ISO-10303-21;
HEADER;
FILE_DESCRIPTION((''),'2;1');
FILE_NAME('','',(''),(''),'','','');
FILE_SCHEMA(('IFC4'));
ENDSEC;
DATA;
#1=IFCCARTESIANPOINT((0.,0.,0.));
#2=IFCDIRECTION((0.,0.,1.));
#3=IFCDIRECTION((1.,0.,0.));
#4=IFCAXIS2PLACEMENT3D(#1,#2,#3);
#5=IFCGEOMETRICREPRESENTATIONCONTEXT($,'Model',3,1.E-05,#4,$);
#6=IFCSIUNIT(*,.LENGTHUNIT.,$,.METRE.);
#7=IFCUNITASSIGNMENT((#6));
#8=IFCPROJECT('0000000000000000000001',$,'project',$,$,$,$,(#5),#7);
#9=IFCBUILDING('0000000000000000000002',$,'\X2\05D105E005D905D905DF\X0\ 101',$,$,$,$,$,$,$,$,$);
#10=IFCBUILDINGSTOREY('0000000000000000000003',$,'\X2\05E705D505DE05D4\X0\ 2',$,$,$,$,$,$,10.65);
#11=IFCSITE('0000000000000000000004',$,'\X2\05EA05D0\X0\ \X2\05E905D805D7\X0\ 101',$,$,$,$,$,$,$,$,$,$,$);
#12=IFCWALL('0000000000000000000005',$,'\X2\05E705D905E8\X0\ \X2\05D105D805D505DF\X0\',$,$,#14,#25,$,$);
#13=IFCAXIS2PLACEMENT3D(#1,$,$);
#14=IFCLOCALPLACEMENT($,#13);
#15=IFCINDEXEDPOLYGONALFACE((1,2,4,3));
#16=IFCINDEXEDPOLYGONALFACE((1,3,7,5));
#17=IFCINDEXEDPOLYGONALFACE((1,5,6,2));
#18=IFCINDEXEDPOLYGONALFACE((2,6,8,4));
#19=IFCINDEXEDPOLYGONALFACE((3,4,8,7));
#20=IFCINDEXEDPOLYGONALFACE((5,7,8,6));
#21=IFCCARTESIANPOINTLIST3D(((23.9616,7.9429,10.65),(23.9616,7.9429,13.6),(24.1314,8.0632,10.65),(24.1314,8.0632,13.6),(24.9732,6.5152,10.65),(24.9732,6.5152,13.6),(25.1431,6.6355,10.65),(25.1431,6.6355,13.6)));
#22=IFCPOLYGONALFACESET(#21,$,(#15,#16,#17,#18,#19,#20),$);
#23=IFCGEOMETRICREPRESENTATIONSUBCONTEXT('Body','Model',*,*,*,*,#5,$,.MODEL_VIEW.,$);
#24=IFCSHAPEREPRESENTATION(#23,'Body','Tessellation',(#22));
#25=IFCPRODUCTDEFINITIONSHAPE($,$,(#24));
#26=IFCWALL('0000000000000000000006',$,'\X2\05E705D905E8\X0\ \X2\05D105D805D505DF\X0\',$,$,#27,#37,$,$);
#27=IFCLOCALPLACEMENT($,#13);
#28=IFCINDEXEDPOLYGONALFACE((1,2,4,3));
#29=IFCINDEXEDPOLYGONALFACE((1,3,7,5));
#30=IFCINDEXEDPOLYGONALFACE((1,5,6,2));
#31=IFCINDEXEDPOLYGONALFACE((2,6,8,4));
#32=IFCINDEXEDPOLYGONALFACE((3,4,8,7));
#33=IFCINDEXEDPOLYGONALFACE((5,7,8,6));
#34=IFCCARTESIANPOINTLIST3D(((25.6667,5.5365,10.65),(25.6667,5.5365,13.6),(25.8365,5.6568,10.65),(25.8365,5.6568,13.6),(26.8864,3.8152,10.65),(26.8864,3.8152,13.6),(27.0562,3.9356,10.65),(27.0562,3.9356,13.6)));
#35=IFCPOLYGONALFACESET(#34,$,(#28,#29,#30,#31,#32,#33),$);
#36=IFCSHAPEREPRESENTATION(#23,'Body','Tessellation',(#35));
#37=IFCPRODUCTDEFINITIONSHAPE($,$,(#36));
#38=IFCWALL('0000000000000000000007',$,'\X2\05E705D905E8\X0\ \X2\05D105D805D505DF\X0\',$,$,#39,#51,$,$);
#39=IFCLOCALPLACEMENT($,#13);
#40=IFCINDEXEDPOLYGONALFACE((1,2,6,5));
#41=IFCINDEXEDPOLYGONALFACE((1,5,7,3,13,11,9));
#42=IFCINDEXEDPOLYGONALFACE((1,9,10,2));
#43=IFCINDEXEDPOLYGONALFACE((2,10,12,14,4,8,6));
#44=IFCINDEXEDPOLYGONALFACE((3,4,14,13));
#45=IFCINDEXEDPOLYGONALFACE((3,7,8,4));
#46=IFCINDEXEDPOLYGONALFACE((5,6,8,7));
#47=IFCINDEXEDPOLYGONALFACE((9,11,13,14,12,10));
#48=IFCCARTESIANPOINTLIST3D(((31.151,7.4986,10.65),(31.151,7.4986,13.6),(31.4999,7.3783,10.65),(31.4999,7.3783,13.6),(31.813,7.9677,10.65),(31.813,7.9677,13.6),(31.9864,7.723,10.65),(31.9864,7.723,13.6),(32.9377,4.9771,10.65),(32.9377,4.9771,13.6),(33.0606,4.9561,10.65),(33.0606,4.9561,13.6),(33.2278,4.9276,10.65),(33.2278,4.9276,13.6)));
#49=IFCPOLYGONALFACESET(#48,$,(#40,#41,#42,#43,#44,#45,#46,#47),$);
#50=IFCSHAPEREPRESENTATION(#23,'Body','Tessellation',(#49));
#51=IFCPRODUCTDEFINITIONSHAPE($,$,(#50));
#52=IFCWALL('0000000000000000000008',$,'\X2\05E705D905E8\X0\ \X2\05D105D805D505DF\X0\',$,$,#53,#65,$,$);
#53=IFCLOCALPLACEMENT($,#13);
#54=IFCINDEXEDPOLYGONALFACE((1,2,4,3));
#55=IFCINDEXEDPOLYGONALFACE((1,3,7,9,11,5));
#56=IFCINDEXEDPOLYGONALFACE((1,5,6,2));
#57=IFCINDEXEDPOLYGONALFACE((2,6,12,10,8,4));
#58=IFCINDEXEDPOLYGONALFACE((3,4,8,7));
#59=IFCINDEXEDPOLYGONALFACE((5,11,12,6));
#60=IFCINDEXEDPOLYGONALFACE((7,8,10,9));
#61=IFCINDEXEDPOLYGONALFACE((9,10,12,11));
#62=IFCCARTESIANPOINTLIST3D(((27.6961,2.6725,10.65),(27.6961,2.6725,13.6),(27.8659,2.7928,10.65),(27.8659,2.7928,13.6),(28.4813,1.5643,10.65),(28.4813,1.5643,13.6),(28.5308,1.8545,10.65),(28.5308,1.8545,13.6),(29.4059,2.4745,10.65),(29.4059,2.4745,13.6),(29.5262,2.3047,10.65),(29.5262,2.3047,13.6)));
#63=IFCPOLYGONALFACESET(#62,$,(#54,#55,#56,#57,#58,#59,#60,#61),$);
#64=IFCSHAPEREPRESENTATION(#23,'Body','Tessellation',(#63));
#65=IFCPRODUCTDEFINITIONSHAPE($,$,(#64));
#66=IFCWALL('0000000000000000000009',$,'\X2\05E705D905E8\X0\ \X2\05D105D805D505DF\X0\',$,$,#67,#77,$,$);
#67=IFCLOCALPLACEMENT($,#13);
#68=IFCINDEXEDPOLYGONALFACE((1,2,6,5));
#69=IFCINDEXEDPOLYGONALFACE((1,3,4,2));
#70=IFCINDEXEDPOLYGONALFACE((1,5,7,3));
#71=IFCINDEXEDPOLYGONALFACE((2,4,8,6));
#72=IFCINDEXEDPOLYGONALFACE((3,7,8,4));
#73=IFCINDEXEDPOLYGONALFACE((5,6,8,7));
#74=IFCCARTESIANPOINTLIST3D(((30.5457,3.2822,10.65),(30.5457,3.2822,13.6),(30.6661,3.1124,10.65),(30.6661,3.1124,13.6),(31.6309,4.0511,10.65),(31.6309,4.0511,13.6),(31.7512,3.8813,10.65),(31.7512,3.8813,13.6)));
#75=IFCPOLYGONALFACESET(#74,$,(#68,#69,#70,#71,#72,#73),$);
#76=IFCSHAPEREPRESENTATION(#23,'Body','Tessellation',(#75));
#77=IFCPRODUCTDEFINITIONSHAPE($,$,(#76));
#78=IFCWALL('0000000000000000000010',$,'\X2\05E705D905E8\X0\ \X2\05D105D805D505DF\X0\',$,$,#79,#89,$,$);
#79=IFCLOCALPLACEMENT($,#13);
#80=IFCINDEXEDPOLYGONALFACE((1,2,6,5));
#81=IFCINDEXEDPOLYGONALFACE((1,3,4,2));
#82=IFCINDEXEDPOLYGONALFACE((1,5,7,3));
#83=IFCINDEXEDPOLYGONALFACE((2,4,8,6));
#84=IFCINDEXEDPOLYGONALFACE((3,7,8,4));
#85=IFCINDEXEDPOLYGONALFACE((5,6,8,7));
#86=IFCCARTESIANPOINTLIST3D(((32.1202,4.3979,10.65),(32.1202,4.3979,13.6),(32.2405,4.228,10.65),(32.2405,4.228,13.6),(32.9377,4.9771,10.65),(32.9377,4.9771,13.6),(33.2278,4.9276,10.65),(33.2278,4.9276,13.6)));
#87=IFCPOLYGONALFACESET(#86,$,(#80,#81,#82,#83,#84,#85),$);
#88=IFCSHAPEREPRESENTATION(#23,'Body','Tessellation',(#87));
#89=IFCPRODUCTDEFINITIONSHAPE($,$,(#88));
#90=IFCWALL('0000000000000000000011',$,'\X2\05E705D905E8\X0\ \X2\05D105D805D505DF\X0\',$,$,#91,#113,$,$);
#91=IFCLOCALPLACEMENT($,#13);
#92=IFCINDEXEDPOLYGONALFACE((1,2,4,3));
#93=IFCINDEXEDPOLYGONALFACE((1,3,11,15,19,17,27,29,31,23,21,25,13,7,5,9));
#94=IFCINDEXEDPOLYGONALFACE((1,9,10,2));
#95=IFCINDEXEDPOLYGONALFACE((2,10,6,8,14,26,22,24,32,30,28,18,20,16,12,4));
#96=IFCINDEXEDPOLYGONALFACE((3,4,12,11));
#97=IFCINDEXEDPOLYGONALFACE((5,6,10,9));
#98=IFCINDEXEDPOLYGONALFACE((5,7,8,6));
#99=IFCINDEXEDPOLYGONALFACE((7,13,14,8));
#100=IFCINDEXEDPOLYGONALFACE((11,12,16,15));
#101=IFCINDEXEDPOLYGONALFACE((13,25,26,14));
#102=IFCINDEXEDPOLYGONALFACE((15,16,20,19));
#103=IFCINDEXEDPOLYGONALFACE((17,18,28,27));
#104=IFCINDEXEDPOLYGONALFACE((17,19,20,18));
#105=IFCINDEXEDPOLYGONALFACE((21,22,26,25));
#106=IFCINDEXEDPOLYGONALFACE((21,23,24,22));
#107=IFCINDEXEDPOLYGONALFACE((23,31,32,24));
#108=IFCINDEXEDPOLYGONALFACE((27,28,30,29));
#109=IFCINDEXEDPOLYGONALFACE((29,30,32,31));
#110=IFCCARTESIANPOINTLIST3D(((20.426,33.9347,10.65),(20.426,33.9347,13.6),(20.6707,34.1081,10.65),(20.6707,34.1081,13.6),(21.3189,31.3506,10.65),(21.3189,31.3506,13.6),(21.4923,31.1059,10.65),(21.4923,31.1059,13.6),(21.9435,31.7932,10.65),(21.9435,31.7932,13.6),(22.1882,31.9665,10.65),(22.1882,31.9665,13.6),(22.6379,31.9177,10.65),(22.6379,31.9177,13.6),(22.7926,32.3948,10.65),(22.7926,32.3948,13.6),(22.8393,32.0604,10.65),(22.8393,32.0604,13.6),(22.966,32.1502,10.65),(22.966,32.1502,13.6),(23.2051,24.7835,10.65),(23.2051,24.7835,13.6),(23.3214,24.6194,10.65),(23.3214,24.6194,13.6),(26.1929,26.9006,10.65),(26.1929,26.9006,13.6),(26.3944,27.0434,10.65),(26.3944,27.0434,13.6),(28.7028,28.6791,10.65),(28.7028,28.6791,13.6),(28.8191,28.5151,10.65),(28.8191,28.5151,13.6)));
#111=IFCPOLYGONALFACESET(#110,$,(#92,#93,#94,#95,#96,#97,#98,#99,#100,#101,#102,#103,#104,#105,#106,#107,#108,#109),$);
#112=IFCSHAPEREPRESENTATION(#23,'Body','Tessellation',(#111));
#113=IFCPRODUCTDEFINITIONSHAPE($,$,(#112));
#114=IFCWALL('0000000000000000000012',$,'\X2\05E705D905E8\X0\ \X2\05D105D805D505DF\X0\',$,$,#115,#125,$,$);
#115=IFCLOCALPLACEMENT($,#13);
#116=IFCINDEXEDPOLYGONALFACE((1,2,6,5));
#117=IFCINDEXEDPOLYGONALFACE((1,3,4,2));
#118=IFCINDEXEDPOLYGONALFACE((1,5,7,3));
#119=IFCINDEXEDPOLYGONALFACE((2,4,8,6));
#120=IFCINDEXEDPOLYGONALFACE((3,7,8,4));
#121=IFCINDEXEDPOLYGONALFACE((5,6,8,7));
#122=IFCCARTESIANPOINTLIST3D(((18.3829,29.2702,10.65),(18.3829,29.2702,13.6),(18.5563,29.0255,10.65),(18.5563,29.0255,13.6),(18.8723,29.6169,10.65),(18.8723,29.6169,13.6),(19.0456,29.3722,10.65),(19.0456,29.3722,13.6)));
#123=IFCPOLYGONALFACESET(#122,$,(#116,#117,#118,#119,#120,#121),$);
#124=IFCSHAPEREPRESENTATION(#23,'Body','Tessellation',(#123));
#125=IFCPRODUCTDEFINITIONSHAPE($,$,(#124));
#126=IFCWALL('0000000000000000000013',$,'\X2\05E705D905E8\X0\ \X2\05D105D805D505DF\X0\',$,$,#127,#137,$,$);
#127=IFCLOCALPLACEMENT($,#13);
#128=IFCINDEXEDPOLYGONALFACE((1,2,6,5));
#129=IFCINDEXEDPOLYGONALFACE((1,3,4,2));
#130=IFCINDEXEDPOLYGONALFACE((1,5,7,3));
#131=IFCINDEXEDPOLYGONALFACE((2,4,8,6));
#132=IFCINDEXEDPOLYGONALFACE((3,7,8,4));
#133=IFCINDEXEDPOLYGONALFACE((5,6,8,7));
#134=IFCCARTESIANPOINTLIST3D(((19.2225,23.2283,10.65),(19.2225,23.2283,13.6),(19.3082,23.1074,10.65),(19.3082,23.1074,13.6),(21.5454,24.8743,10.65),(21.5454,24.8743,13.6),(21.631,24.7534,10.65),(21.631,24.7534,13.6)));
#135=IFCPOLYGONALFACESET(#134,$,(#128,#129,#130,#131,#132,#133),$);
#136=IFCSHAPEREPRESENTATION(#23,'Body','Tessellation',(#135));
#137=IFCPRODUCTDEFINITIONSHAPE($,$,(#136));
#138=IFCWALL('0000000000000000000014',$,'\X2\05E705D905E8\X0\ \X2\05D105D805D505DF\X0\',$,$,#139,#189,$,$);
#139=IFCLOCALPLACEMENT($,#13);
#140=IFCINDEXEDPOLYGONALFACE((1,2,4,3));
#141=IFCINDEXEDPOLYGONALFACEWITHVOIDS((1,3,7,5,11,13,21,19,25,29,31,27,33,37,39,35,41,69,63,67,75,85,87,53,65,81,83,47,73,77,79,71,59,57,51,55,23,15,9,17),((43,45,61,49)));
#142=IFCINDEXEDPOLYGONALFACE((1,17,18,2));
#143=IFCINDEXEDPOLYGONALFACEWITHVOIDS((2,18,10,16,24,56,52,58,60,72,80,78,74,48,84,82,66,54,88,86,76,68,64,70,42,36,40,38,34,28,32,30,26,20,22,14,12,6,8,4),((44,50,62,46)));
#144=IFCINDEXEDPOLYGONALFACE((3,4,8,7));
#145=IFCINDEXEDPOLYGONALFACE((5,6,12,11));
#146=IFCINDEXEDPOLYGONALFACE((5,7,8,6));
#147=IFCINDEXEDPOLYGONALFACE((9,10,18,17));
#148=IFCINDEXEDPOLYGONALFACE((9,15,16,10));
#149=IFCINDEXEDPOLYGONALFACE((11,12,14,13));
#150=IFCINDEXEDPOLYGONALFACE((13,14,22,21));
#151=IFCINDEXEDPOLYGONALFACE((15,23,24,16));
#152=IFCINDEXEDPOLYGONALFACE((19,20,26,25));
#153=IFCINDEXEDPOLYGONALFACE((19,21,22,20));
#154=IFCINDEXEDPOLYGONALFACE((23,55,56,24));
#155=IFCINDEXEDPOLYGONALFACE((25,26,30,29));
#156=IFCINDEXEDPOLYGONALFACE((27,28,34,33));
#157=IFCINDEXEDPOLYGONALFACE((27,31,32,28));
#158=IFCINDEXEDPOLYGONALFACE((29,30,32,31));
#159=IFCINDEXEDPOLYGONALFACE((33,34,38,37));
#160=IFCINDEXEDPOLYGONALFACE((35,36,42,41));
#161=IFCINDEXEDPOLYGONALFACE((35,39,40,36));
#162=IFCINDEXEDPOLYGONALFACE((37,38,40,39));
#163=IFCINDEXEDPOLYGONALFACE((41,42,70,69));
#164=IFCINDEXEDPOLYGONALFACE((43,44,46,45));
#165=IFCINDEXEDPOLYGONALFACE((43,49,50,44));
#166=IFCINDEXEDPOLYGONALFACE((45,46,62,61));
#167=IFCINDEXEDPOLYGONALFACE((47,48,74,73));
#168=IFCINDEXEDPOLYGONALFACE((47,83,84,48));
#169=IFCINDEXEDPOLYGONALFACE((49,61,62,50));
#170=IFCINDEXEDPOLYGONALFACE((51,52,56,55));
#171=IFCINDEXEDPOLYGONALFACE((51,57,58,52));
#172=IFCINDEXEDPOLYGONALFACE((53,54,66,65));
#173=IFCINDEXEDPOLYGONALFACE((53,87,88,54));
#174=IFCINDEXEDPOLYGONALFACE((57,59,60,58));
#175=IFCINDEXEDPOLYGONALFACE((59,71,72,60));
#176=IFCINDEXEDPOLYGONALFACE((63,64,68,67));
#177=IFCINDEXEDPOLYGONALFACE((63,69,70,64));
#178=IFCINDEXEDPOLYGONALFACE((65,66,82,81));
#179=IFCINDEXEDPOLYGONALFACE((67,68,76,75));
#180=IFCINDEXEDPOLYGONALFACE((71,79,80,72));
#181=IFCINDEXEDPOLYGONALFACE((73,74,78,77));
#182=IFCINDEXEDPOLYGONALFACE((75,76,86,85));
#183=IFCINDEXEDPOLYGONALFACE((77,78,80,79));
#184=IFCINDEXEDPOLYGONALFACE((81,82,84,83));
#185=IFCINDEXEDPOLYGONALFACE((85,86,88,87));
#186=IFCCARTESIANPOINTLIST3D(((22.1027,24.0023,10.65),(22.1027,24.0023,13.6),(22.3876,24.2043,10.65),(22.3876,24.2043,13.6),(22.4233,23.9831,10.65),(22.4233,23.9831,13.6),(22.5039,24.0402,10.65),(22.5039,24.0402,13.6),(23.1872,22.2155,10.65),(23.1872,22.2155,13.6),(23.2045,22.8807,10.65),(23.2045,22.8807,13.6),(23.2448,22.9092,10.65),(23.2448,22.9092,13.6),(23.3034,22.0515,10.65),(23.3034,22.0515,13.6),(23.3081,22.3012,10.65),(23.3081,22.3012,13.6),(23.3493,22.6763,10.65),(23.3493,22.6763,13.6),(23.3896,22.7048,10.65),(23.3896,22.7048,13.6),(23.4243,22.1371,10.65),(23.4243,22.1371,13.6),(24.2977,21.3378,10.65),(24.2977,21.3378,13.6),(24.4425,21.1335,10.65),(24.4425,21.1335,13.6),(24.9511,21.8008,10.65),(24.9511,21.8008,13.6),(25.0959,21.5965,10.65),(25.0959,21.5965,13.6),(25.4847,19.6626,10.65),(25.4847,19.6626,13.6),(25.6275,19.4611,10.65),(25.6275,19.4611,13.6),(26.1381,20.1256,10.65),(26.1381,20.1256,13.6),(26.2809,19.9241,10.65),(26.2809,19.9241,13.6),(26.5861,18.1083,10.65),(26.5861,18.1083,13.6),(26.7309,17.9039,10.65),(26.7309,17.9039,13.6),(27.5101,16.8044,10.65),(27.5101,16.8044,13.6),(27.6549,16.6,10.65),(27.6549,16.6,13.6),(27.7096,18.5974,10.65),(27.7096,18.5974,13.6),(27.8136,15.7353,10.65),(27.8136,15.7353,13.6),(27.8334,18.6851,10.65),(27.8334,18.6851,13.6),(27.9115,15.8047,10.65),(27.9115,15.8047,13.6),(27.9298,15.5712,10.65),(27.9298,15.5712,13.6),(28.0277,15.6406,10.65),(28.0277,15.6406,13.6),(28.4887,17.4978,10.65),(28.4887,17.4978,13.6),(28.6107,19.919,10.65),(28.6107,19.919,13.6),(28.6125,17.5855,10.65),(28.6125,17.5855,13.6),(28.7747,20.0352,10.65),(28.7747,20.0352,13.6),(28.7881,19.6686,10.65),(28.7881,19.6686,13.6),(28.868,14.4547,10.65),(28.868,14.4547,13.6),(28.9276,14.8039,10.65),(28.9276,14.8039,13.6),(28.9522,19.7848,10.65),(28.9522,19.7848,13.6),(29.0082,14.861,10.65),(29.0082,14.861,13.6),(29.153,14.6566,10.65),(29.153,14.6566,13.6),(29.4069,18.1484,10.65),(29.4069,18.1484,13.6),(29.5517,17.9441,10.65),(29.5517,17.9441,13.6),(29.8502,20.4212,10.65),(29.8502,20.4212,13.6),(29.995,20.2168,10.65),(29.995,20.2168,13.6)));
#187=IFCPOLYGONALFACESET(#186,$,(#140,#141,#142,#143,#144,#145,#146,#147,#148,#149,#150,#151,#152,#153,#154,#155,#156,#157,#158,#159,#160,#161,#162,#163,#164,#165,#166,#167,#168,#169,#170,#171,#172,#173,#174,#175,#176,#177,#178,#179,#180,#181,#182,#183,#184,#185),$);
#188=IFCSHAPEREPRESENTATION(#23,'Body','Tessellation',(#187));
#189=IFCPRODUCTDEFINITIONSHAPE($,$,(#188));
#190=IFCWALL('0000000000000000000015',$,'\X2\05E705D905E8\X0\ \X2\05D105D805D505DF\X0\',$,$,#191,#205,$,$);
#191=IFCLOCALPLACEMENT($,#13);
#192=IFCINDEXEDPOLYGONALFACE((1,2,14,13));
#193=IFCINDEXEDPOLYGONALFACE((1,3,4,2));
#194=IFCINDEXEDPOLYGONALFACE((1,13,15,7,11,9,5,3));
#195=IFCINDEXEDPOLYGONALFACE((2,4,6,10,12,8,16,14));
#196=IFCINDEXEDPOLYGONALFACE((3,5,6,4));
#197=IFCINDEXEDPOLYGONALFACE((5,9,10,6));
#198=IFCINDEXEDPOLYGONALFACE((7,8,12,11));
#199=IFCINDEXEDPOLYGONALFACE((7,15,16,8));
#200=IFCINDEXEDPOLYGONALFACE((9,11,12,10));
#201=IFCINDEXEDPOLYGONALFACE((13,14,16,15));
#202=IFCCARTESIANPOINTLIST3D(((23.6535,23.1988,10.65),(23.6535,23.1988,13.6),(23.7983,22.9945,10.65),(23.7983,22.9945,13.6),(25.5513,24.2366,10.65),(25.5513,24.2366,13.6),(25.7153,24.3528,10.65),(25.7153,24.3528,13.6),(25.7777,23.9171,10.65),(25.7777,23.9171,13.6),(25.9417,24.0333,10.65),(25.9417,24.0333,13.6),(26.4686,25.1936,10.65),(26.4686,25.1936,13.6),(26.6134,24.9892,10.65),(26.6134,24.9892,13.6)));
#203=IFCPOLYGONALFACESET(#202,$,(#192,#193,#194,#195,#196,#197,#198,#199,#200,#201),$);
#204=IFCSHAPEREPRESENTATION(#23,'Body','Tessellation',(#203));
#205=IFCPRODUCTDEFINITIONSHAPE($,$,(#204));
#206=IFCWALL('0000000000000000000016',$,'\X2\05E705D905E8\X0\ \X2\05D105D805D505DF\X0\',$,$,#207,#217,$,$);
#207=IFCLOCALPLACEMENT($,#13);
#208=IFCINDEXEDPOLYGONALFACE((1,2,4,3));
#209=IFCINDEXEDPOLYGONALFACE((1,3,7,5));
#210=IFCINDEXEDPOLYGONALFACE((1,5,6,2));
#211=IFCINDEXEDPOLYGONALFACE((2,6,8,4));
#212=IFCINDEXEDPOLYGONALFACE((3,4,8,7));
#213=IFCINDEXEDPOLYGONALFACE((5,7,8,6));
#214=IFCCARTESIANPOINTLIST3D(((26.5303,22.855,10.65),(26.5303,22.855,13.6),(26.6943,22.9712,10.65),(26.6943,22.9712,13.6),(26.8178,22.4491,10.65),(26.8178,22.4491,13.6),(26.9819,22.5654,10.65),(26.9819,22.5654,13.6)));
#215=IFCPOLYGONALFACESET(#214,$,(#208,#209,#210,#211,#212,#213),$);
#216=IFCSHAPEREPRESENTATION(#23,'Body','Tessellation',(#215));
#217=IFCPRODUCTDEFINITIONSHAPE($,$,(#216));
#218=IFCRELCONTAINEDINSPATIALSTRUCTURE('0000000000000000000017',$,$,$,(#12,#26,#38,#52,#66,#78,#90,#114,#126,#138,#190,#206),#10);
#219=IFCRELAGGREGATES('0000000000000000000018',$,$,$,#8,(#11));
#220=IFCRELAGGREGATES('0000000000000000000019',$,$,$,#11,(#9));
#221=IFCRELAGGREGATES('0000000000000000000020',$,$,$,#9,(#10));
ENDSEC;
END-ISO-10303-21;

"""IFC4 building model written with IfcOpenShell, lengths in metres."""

from ifc_helpers import new_model, si_unit, frame, origin_with_axes, context, subcontext, project, spatial, polyline, outline, extrude, element, save


model = new_model("IFC4")

# Units and contexts
model_context = context("Model", 3, precision=1e-05, world=origin_with_axes())
body_context = subcontext(model_context, "Body", "Model", "MODEL_VIEW")
ifc_project = project(units=[si_unit("LENGTHUNIT", "METRE")], contexts=[model_context])

# Site, building, storey
site = spatial("IfcSite", under=ifc_project, Name="תא שטח 101")
building = spatial("IfcBuilding", under=site, Name="בניין 101")
storey = spatial("IfcBuildingStorey", under=building, Name="קומה 2", Elevation=10.65)

# Walls
element("IfcWall", 1, inside=storey, Name="קיר בטון", context=body_context, shape_type="SweptSolid", body=[
    extrude(outline(polyline([(23.9616, 7.9429), (24.9732, 6.5152), (25.1431, 6.6355), (24.1314, 8.0632), (23.9616, 7.9429)])), frame((0.0, 0.0, 10.65)), (0.0, 0.0, 1.0), 2.95),
])
element("IfcWall", 2, inside=storey, Name="קיר בטון", context=body_context, shape_type="SweptSolid", body=[
    extrude(outline(polyline([(25.8365, 5.6568), (25.6667, 5.5365), (26.8864, 3.8152), (27.0562, 3.9356), (25.8365, 5.6568)])), frame((0.0, 0.0, 10.65)), (0.0, 0.0, 1.0), 2.95),
])
element("IfcWall", 3, inside=storey, Name="קיר בטון", context=body_context, shape_type="SweptSolid", body=[
    extrude(outline(polyline([(31.4999, 7.3783), (31.9864, 7.723), (31.813, 7.9677), (31.151, 7.4986), (32.9377, 4.9771), (33.0606, 4.9561), (33.2278, 4.9276), (31.4999, 7.3783)])), frame((0.0, 0.0, 10.65)), (0.0, 0.0, 1.0), 2.95),
])
element("IfcWall", 4, inside=storey, Name="קיר בטון", context=body_context, shape_type="SweptSolid", body=[
    extrude(outline(polyline([(29.5262, 2.3047), (29.4059, 2.4745), (28.5308, 1.8545), (27.8659, 2.7928), (27.6961, 2.6725), (28.4813, 1.5643), (29.5262, 2.3047)])), frame((0.0, 0.0, 10.65)), (0.0, 0.0, 1.0), 2.95),
])
element("IfcWall", 5, inside=storey, Name="קיר בטון", context=body_context, shape_type="SweptSolid", body=[
    extrude(outline(polyline([(30.6661, 3.1124), (31.7512, 3.8813), (31.6309, 4.0511), (30.5457, 3.2822), (30.6661, 3.1124)])), frame((0.0, 0.0, 10.65)), (0.0, 0.0, 1.0), 2.95),
])
element("IfcWall", 6, inside=storey, Name="קיר בטון", context=body_context, shape_type="SweptSolid", body=[
    extrude(outline(polyline([(32.9377, 4.9771), (32.1202, 4.3979), (32.2405, 4.228), (33.2278, 4.9276), (32.9377, 4.9771)])), frame((0.0, 0.0, 10.65)), (0.0, 0.0, 1.0), 2.95),
])
element("IfcWall", 7, inside=storey, Name="קיר בטון", context=body_context, shape_type="SweptSolid", body=[
    extrude(outline(polyline([(21.4923, 31.1059), (22.6379, 31.9177), (26.1929, 26.9006), (23.2051, 24.7835), (23.3214, 24.6194), (28.8191, 28.5151), (28.7028, 28.6791), (26.3944, 27.0434), (22.8393, 32.0604), (22.966, 32.1502), (22.7926, 32.3948), (22.1882, 31.9665), (20.6707, 34.1081), (20.426, 33.9347), (21.9435, 31.7932), (21.3189, 31.3506), (21.4923, 31.1059)])), frame((0.0, 0.0, 10.65)), (0.0, 0.0, 1.0), 2.95),
])
element("IfcWall", 8, inside=storey, Name="קיר בטון", context=body_context, shape_type="SweptSolid", body=[
    extrude(outline(polyline([(18.8723, 29.6169), (18.3829, 29.2702), (18.5563, 29.0255), (19.0456, 29.3722), (18.8723, 29.6169)])), frame((0.0, 0.0, 10.65)), (0.0, 0.0, 1.0), 2.95),
])
element("IfcWall", 9, inside=storey, Name="קיר בטון", context=body_context, shape_type="SweptSolid", body=[
    extrude(outline(polyline([(21.631, 24.7534), (21.5454, 24.8743), (19.2225, 23.2283), (19.3082, 23.1074), (21.631, 24.7534)])), frame((0.0, 0.0, 10.65)), (0.0, 0.0, 1.0), 2.95),
])
element("IfcWall", 10, inside=storey, Name="קיר בטון", context=body_context, shape_type="SweptSolid", body=[
    extrude(outline(polyline([(23.1872, 22.2155), (23.3034, 22.0515), (23.4243, 22.1371), (27.9115, 15.8047), (27.8136, 15.7353), (27.9298, 15.5712), (28.0277, 15.6406), (28.868, 14.4547), (29.153, 14.6566), (29.0082, 14.861), (28.9276, 14.8039), (27.6549, 16.6), (29.5517, 17.9441), (29.4069, 18.1484), (28.6125, 17.5855), (27.8334, 18.6851), (29.995, 20.2168), (29.8502, 20.4212), (28.9522, 19.7848), (28.7747, 20.0352), (28.6107, 19.919), (28.7881, 19.6686), (26.5861, 18.1083), (25.6275, 19.4611), (26.2809, 19.9241), (26.1381, 20.1256), (25.4847, 19.6626), (24.4425, 21.1335), (25.0959, 21.5965), (24.9511, 21.8008), (24.2977, 21.3378), (23.3493, 22.6763), (23.3896, 22.7048), (23.2448, 22.9092), (23.2045, 22.8807), (22.4233, 23.9831), (22.5039, 24.0402), (22.3876, 24.2043), (22.1027, 24.0023), (23.3081, 22.3012), (23.1872, 22.2155)]), holes=[polyline([(27.7096, 18.5974), (28.4887, 17.4978), (27.5101, 16.8044), (26.7309, 17.9039), (27.7096, 18.5974)])]), frame((0.0, 0.0, 10.65)), (0.0, 0.0, 1.0), 2.95),
])
element("IfcWall", 11, inside=storey, Name="קיר בטון", context=body_context, shape_type="SweptSolid", body=[
    extrude(outline(polyline([(25.7777, 23.9171), (25.9417, 24.0333), (25.7153, 24.3528), (26.6134, 24.9892), (26.4686, 25.1936), (23.6535, 23.1988), (23.7983, 22.9945), (25.5513, 24.2366), (25.7777, 23.9171)])), frame((0.0, 0.0, 10.65)), (0.0, 0.0, 1.0), 2.95),
])
element("IfcWall", 12, inside=storey, Name="קיר בטון", context=body_context, shape_type="SweptSolid", body=[
    extrude(outline(polyline([(26.9819, 22.5654), (26.6943, 22.9712), (26.5303, 22.855), (26.8178, 22.4491), (26.9819, 22.5654)])), frame((0.0, 0.0, 10.65)), (0.0, 0.0, 1.0), 2.95),
])

save(model, "model.ifc")
